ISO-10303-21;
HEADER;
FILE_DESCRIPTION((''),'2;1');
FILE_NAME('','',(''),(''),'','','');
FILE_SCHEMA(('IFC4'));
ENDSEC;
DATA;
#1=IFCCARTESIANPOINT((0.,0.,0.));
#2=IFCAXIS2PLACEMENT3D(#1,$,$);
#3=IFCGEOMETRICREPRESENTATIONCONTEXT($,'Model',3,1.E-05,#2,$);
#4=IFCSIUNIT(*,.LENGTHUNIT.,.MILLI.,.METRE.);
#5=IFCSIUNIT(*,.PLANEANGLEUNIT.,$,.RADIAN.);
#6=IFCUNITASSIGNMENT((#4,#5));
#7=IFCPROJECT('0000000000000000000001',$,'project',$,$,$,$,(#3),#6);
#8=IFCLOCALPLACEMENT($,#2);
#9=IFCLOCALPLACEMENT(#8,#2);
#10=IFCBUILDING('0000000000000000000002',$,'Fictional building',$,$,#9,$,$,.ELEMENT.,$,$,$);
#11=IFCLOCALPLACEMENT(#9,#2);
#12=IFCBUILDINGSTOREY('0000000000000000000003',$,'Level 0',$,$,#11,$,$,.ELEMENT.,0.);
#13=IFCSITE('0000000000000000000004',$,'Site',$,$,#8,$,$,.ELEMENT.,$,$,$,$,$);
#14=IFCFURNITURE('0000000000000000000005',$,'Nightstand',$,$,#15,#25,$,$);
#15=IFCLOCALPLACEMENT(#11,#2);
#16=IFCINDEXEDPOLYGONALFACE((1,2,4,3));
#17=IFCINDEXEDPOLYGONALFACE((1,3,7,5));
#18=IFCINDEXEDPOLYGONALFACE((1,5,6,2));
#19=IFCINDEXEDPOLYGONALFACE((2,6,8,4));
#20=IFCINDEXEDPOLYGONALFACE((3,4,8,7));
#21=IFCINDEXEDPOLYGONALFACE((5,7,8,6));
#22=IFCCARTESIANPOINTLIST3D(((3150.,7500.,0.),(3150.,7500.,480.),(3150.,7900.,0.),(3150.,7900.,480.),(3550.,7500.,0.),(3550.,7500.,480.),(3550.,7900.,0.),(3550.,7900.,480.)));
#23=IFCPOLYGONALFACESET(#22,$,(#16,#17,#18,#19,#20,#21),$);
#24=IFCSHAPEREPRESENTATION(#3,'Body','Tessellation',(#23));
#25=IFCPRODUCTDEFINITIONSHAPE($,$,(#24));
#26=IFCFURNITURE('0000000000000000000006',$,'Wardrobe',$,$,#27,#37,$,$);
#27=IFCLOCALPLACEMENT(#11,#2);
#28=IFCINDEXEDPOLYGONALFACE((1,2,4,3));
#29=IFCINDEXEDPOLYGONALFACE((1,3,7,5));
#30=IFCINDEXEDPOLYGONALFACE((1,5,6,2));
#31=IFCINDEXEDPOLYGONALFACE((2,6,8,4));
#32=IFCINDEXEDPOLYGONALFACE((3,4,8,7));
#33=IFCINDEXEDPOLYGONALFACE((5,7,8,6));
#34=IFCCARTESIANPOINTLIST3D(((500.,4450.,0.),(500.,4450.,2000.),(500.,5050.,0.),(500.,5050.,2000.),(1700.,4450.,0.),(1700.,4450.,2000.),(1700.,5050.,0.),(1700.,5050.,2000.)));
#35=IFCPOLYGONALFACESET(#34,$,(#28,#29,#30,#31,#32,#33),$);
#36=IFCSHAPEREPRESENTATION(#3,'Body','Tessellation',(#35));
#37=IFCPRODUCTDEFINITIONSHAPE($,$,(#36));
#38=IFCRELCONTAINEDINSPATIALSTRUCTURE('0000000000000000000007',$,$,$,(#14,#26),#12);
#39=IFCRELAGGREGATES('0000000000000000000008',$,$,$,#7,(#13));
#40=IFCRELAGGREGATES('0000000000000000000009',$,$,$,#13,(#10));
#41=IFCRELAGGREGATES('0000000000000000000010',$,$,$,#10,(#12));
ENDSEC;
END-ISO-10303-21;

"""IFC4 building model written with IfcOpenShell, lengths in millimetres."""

from ifc_helpers import new_model, si_unit, frame, origin, origin_2d, place, context, project, spatial, rectangle, extrude, source, transform, mapped, element, save


model = new_model("IFC4")

# Units and contexts
model_context = context("Model", 3, precision=1e-05, world=origin())
ifc_project = project(units=[si_unit("LENGTHUNIT", "METRE", prefix="MILLI"), si_unit("PLANEANGLEUNIT", "RADIAN")], contexts=[model_context])

# Site, building, storey
site_placement = place(None, origin())
site = spatial("IfcSite", under=ifc_project, at=site_placement, Name="Site", CompositionType="ELEMENT")
building_placement = place(site_placement, origin())
building = spatial("IfcBuilding", under=site, at=building_placement, Name="Fictional building", CompositionType="ELEMENT")
storey_placement = place(building_placement, origin())
storey = spatial("IfcBuildingStorey", under=building, at=storey_placement, Name="Level 0", CompositionType="ELEMENT", Elevation=0.0)

# Furniture
shared_shape_1 = source(origin(), model_context, "Body", "SweptSolid", [
    extrude(rectangle(XDim=400.0, YDim=400.0, at=origin_2d()), origin(), (0.0, 0.0, 1.0), 480.0),
])
for number, where, name in (
    (1, (3350.0, 7700.0, 0.0), "Nightstand"),
):
    element("IfcFurniture", number, at=place(storey_placement, frame(where)), inside=storey, Name=name, context=model_context, shape_type="MappedRepresentation", body=[
        mapped(shared_shape_1, transform((0.0, 0.0, 0.0), scale=1.0)),
    ])
shared_shape_2 = source(origin(), model_context, "Body", "SweptSolid", [
    extrude(rectangle(XDim=1200.0, YDim=600.0, at=origin_2d()), origin(), (0.0, 0.0, 1.0), 2000.0),
])
furniture_1_placement = place(storey_placement, frame((1100.0, 4750.0, 0.0), z_axis=(0.0, 0.0, 1.0), x_axis=(-1.0, 0.0, 0.0)))
element("IfcFurniture", 2, at=furniture_1_placement, inside=storey, Name="Wardrobe", context=model_context, shape_type="MappedRepresentation", body=[
    mapped(shared_shape_2, transform((0.0, 0.0, 0.0), scale=1.0)),
])

save(model, "model.ifc")
